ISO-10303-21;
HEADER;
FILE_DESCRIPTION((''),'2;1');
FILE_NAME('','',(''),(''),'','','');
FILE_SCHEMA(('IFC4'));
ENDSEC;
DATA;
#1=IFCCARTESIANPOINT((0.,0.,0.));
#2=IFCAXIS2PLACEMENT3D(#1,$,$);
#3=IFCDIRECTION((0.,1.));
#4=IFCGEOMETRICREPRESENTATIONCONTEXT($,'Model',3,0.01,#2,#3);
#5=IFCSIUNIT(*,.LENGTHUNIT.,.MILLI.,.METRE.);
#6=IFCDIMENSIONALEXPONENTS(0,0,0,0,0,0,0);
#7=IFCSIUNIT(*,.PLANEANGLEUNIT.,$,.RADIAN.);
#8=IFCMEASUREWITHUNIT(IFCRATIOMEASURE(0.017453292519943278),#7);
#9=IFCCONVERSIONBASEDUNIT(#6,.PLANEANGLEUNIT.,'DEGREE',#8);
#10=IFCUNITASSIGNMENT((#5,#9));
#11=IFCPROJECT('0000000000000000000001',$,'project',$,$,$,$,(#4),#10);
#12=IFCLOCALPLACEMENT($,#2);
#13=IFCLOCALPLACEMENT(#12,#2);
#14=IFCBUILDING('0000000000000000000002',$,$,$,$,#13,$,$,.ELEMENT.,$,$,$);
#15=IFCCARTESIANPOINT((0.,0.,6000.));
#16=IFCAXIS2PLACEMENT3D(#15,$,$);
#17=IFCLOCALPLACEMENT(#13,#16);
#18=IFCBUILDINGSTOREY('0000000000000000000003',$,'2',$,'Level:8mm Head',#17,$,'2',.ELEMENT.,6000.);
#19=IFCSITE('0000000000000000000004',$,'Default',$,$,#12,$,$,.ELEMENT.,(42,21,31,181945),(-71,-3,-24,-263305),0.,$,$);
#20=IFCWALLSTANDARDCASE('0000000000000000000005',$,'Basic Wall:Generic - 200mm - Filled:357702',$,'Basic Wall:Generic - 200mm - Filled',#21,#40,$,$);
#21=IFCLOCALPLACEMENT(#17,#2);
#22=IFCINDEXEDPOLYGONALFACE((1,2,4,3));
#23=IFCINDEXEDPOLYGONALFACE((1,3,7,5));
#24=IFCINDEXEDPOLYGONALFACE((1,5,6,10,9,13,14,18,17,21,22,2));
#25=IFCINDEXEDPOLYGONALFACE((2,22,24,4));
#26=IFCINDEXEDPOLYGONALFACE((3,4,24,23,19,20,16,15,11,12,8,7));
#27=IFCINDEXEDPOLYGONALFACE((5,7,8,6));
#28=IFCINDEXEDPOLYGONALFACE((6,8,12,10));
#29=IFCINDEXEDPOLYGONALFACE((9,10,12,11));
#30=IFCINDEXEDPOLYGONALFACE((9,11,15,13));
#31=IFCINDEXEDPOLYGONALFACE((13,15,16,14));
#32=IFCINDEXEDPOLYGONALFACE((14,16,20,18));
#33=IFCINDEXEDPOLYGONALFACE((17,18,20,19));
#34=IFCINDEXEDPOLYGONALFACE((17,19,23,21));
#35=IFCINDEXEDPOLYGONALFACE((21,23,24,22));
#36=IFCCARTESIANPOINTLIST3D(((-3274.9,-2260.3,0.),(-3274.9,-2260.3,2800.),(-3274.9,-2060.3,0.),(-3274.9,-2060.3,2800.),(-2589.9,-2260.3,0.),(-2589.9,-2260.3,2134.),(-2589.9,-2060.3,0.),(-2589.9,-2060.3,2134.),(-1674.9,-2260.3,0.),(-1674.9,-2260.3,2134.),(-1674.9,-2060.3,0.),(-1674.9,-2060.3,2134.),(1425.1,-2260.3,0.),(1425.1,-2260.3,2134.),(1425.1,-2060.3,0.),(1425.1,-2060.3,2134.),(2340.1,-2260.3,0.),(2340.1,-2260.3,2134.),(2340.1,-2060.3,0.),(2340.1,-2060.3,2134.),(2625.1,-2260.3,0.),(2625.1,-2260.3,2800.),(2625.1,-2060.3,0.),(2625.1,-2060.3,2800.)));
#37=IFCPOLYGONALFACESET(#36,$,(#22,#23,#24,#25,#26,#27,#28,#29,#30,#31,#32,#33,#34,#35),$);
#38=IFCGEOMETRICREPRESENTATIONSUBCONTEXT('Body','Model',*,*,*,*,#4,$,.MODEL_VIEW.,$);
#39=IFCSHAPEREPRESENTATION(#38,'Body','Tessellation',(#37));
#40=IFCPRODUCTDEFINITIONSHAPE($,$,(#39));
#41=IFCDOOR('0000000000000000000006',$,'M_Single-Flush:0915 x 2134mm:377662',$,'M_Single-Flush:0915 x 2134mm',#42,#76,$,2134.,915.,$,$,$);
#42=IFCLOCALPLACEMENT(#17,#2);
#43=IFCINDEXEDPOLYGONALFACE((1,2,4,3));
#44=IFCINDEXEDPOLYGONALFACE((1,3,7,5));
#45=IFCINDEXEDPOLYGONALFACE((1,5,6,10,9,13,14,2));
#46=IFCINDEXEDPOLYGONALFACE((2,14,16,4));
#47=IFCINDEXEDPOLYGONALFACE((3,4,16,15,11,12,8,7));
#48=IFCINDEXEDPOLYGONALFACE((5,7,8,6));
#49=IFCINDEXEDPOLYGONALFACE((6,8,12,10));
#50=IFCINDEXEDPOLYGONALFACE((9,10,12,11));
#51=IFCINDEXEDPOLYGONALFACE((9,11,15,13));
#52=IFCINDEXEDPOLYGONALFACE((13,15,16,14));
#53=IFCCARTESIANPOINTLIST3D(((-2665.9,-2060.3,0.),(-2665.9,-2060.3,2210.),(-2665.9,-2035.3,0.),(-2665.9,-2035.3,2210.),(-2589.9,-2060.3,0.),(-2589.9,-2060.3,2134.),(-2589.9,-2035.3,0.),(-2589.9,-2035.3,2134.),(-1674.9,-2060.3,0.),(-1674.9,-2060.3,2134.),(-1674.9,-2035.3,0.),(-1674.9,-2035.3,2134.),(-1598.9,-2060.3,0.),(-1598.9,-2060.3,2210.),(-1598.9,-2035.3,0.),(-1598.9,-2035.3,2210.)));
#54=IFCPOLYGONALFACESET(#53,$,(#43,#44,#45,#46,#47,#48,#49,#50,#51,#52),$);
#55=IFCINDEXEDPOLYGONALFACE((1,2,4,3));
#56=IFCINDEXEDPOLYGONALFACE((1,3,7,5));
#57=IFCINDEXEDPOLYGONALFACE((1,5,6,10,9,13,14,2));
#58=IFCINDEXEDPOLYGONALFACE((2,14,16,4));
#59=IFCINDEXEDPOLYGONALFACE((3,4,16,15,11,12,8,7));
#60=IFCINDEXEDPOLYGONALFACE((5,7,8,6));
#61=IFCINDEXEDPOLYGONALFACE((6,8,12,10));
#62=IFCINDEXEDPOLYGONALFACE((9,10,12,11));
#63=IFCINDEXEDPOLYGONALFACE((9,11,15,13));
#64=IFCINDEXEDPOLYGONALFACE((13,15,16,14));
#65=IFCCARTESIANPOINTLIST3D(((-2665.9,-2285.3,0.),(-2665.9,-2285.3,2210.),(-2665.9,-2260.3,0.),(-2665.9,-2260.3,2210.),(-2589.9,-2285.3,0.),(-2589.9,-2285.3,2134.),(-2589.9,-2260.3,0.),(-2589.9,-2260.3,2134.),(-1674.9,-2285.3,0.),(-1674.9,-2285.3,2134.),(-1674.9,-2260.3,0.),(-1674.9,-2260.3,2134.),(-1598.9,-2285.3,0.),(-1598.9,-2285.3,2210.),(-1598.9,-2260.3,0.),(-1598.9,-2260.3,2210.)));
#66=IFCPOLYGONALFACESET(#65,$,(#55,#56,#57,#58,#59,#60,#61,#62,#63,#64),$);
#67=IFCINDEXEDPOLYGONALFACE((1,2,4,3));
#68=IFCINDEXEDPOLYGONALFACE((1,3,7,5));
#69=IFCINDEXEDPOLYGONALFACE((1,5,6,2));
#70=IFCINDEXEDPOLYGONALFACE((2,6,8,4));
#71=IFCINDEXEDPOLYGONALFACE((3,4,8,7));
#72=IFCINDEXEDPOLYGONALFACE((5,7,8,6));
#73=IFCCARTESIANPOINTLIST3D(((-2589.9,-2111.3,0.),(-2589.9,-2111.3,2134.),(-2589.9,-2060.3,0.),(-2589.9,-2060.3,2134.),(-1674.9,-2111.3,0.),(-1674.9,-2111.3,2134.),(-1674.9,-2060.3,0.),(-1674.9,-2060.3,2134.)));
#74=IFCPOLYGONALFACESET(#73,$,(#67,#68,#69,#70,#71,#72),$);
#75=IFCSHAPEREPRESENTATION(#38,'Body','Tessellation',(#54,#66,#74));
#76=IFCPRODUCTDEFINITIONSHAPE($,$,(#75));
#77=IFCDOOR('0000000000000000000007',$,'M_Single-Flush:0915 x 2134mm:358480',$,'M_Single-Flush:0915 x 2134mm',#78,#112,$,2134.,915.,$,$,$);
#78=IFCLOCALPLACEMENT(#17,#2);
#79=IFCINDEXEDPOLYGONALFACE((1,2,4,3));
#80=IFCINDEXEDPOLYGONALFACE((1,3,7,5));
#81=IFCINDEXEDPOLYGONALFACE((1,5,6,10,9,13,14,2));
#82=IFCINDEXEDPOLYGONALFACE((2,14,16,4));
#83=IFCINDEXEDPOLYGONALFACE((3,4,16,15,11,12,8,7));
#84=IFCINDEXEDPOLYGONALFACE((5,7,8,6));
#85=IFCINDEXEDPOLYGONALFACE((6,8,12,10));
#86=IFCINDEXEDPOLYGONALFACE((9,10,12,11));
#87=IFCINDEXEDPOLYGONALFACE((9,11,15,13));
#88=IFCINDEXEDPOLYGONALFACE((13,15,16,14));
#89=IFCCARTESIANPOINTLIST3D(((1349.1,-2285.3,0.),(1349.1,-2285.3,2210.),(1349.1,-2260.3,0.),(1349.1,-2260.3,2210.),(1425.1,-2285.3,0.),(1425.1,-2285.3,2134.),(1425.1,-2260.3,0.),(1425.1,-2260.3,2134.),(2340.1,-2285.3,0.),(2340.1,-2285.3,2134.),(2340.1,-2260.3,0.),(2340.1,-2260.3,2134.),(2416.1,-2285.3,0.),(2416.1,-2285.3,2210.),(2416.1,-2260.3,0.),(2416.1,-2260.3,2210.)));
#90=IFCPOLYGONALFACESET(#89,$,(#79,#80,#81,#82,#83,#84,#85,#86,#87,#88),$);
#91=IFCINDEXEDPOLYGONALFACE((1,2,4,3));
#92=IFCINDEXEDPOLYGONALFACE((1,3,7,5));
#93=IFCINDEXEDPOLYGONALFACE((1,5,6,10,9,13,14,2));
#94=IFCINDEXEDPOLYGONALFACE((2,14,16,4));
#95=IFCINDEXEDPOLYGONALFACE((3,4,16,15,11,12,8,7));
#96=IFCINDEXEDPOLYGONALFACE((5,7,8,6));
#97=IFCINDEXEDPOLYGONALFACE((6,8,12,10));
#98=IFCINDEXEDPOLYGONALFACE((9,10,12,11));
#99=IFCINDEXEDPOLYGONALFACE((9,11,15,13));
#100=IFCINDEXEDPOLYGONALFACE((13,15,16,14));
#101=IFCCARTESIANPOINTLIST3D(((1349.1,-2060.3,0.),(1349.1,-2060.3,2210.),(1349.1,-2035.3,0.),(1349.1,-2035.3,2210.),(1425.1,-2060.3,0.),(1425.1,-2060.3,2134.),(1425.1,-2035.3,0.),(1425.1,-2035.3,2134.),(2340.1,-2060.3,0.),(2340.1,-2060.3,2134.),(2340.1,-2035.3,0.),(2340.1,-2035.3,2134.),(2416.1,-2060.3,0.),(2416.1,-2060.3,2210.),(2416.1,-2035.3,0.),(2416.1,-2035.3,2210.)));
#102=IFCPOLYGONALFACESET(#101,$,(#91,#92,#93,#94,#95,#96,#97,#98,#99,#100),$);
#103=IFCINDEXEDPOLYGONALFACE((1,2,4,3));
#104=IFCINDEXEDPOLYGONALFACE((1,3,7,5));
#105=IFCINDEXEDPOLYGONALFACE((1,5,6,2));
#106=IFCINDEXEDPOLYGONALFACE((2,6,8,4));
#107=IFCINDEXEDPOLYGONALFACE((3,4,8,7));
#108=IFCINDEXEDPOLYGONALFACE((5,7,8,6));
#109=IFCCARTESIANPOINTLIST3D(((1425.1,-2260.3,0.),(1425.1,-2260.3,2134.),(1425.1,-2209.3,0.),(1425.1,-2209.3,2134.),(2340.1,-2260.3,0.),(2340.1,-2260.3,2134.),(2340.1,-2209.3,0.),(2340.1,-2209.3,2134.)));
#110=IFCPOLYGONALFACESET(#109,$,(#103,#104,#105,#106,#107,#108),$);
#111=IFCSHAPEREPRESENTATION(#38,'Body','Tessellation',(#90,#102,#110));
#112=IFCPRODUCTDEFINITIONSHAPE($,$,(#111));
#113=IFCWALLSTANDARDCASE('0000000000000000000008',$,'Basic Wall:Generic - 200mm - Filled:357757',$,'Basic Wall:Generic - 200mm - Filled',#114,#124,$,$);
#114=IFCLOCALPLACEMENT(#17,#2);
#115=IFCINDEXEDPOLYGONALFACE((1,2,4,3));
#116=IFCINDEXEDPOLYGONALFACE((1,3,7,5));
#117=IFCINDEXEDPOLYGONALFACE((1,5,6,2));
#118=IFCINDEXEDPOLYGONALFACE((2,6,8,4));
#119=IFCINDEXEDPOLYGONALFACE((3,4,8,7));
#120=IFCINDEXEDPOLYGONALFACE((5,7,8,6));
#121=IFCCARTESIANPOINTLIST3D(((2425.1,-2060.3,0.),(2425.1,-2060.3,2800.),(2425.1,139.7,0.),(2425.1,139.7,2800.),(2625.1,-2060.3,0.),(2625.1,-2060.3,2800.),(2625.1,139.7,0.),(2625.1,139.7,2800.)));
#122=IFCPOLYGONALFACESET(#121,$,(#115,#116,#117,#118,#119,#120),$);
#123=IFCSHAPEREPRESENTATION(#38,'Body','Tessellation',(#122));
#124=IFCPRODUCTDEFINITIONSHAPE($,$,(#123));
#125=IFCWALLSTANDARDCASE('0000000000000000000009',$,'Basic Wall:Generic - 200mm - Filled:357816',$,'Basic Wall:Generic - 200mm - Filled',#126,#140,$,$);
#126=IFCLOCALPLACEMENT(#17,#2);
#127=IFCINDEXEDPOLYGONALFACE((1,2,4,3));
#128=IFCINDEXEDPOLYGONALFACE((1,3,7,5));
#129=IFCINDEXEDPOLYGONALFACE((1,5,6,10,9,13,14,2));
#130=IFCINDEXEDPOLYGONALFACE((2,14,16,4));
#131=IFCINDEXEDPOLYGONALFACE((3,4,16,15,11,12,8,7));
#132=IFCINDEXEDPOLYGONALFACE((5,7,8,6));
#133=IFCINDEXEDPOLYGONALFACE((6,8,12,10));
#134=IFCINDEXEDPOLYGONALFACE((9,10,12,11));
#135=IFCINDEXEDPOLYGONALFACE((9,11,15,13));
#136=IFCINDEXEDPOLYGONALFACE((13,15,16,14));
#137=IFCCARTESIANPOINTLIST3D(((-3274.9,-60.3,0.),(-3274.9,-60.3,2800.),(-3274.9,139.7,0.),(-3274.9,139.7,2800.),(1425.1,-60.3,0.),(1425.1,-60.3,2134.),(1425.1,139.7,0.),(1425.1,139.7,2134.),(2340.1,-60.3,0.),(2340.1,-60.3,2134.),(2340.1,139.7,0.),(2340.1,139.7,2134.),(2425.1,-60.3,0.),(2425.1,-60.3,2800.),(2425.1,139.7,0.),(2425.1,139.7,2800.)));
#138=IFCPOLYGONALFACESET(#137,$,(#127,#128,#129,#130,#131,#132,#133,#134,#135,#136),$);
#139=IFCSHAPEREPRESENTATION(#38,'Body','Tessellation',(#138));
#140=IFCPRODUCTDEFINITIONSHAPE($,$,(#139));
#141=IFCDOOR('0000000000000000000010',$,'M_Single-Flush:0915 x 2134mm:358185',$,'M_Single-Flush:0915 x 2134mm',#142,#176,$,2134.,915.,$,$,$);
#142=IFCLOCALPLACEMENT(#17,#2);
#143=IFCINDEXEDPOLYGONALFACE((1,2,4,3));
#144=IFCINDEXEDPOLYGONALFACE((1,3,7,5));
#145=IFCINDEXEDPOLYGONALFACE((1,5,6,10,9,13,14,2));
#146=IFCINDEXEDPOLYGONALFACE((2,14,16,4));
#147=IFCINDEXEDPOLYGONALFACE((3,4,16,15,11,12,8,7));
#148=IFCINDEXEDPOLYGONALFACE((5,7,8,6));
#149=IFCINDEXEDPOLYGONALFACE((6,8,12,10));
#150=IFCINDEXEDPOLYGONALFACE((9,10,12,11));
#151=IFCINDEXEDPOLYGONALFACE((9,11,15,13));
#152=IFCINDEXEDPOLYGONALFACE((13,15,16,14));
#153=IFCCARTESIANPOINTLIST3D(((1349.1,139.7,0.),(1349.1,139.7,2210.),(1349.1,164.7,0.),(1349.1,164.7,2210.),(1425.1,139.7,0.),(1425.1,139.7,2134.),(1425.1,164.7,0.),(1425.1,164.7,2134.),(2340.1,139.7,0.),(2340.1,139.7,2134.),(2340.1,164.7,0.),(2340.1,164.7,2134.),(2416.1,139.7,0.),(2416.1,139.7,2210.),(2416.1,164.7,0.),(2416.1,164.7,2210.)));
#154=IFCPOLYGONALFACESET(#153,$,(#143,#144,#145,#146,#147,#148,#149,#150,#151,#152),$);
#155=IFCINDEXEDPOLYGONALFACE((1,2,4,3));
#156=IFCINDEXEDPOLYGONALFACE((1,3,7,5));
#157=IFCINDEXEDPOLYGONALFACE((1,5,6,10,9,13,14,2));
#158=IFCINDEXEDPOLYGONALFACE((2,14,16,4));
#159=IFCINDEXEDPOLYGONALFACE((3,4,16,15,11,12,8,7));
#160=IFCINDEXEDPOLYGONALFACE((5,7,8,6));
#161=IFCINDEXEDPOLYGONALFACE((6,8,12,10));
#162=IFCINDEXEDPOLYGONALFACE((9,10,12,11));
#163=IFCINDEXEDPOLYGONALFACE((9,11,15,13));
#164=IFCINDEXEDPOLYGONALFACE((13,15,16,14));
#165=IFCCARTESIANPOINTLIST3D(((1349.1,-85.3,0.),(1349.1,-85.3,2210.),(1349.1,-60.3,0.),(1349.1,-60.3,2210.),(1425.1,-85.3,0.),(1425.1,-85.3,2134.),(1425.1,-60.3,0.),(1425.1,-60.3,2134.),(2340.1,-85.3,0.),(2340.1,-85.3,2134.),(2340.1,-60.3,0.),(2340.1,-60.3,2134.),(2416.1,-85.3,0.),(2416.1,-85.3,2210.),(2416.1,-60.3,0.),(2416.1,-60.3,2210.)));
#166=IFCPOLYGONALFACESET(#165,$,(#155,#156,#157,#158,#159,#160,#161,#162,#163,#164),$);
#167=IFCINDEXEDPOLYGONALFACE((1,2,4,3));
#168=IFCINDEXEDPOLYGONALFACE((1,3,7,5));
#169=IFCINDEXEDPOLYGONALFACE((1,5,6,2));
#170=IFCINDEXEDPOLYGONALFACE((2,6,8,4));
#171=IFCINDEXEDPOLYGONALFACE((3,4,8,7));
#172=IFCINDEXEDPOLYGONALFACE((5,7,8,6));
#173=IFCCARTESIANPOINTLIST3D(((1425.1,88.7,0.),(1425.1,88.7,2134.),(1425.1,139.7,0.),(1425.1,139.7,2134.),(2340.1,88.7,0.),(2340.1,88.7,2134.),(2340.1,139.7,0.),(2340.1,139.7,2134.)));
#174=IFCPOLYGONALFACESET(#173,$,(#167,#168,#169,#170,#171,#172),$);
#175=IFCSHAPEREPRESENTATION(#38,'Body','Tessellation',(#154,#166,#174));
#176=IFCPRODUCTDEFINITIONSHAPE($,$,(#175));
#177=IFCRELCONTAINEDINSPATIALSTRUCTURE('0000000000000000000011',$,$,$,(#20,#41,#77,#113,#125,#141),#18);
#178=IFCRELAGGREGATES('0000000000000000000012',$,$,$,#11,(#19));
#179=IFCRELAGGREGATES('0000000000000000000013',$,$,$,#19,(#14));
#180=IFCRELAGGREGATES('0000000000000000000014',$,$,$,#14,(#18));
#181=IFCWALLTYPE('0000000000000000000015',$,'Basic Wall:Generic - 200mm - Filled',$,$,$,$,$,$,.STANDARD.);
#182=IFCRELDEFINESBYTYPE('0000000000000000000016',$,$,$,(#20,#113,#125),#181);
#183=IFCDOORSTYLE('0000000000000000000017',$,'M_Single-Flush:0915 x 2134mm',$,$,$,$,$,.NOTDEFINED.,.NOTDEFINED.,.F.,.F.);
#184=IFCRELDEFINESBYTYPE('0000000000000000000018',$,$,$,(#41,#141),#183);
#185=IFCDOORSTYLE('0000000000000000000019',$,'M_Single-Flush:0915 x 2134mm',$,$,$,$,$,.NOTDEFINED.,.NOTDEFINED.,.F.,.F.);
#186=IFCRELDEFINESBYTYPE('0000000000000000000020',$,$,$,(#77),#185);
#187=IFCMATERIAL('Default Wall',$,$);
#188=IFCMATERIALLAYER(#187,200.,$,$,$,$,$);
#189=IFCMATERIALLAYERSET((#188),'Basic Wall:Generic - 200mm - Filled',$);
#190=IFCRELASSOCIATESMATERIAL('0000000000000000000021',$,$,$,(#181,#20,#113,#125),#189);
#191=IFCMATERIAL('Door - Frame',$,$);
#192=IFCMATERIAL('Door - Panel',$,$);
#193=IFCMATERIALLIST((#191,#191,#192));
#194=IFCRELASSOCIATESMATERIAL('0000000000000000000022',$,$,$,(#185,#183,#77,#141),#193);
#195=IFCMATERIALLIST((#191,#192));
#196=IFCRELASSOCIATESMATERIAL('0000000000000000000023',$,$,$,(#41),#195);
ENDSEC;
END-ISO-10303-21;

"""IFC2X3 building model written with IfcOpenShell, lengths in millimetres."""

from ifc_helpers import new_model, entity, si_unit, converted_unit, direction, frame, frame_2d, origin, place, context, subcontext, project, spatial, polyline, rectangle, outline, extrude, source, transform, mapped, material, material_list, layer, layer_set, layer_usage, type_object, type_shapes, element, fill, save


model = new_model("IFC2X3")

# Units and contexts
model_context = context("Model", 3, precision=0.01, world=origin(), true_north=direction((0.0, 1.0)))
body_context = subcontext(model_context, "Body", "Model", "MODEL_VIEW")
ifc_project = project(units=[si_unit("LENGTHUNIT", "METRE", prefix="MILLI"), converted_unit("PLANEANGLEUNIT", "DEGREE", entity("IfcRatioMeasure", 0.017453292519943278), si_unit("PLANEANGLEUNIT", "RADIAN"), dimensions=[0, 0, 0, 0, 0, 0, 0])], contexts=[model_context])

# Site, building, storey
site_placement = place(None, origin())
site = spatial("IfcSite", under=ifc_project, at=site_placement, Name="Default", CompositionType="ELEMENT", RefLatitude=(42, 21, 31, 181945), RefLongitude=(-71, -3, -24, -263305), RefElevation=0.0)
building_placement = place(site_placement, origin())
building = spatial("IfcBuilding", under=site, at=building_placement, CompositionType="ELEMENT")
storey_placement = place(building_placement, frame((0.0, 0.0, 6000.0)))
storey = spatial("IfcBuildingStorey", under=building, at=storey_placement, Name="2", ObjectType="Level:8mm Head", LongName="2", CompositionType="ELEMENT", Elevation=6000.0)

# Shared definitions
ifc_material_1 = material(Name="Default Wall")
ifc_layer_1 = layer(ifc_material_1, 200.0)
ifc_layer_set_1 = layer_set([ifc_layer_1], Name="Basic Wall:Generic - 200mm - Filled")
ifc_layer_usage_1 = layer_usage(ifc_layer_set_1, "AXIS2", "NEGATIVE", 100.0)
wall_type_1 = type_object("IfcWallType", Name="Basic Wall:Generic - 200mm - Filled", PredefinedType="STANDARD", material=ifc_layer_set_1)
ifc_material_2 = material(Name="Door - Frame")
ifc_material_3 = material(Name="Door - Panel")
ifc_material_list_1 = material_list([ifc_material_2, ifc_material_3])
ifc_material_list_2 = material_list([ifc_material_2, ifc_material_2, ifc_material_3])
door_style_1 = type_object("IfcDoorStyle", Name="M_Single-Flush:0915 x 2134mm", ConstructionType="NOTDEFINED", OperationType="NOTDEFINED", ParameterTakesPrecedence=False, Sizeable=False, material=ifc_material_list_2)
shared_shape_1 = source(origin(), body_context, "Body", "SweptSolid", [
    extrude(outline(polyline([(-533.5, -1124.0), (533.5, -1124.0), (533.5, 1086.0), (457.5, 1086.0), (457.5, -1048.0), (-457.5, -1048.0), (-457.5, 1086.0), (-533.5, 1086.0), (-533.5, -1124.0)])), frame((457.5, 200.0, 1086.0), z_axis=(0.0, 1.0, 0.0), x_axis=(1.0, 0.0, 0.0)), (0.0, 0.0, 1.0), 25.0),
    extrude(outline(polyline([(-1124.0, -533.5), (1086.0, -533.5), (1086.0, -457.5), (-1048.0, -457.5), (-1048.0, 457.5), (1086.0, 457.5), (1086.0, 533.5), (-1124.0, 533.5), (-1124.0, -533.5)])), frame((457.5, -25.0, 1086.0), z_axis=(0.0, 1.0, 0.0), x_axis=(0.0, 0.0, -1.0)), (0.0, 0.0, 1.0), 25.0),
    extrude(rectangle(XDim=51.0, YDim=915.0, at=frame_2d((0.0, 0.0), x_axis=(1.0, 0.0))), frame((457.5, 174.5, 0.0), z_axis=(0.0, 0.0, 1.0), x_axis=(0.0, 1.0, 0.0)), (0.0, 0.0, 1.0), 2134.0),
])
type_shapes(door_style_1, [shared_shape_1])

# Wall, openings, doors
wall_1_placement = place(storey_placement, frame((-3274.9, -2160.3, 0.0)))
wall_1 = element("IfcWallStandardCase", 1, at=wall_1_placement, inside=storey, type_object=wall_type_1, material=ifc_layer_usage_1, Name="Basic Wall:Generic - 200mm - Filled:357702", ObjectType="Basic Wall:Generic - 200mm - Filled", context=body_context, shape_type="SweptSolid", body=[
    extrude(rectangle(XDim=5900.0, YDim=200.0, at=frame_2d((2950.0, 0.0), x_axis=(1.0, 0.0))), origin(), (0.0, 0.0, 1.0), 2800.0),
])
opening_1_placement = place(wall_1_placement, frame((5615.0, 100.0, 0.0)))
opening_1 = element("IfcOpeningElement", 2, at=opening_1_placement, cuts=wall_1, ObjectType="Opening", context=body_context, shape_type="SweptSolid", body=[
    extrude(rectangle(XDim=915.0, YDim=2134.0, at=frame_2d((1067.0, 457.5), x_axis=(0.0, 1.0))), frame((0.0, 0.0, 0.0), z_axis=(0.0, -1.0, 0.0), x_axis=(0.0, 0.0, 1.0)), (0.0, 0.0, 1.0), 200.0),
])
opening_2_placement = place(wall_1_placement, frame((685.0, -100.0, 0.0)))
opening_2 = element("IfcOpeningElement", 3, at=opening_2_placement, cuts=wall_1, ObjectType="Opening", context=body_context, shape_type="SweptSolid", body=[
    extrude(rectangle(XDim=915.0, YDim=2134.0, at=frame_2d((1067.0, 457.5), x_axis=(0.0, -1.0))), frame((0.0, 0.0, 0.0), z_axis=(0.0, 1.0, 0.0), x_axis=(0.0, 0.0, 1.0)), (0.0, 0.0, 1.0), 200.0),
])
door_style_2 = type_object("IfcDoorStyle", Name="M_Single-Flush:0915 x 2134mm", ConstructionType="NOTDEFINED", OperationType="NOTDEFINED", ParameterTakesPrecedence=False, Sizeable=False, material=ifc_material_list_2)
shared_shape_2 = source(origin(), body_context, "Body", "SweptSolid", [
    extrude(outline(polyline([(-533.5, -1124.0), (533.5, -1124.0), (533.5, 1086.0), (457.5, 1086.0), (457.5, -1048.0), (-457.5, -1048.0), (-457.5, 1086.0), (-533.5, 1086.0), (-533.5, -1124.0)])), frame((457.5, 225.0, 1086.0), z_axis=(0.0, -1.0, 0.0), x_axis=(-1.0, 0.0, 0.0)), (0.0, 0.0, 1.0), 25.0),
    extrude(outline(polyline([(-1124.0, -533.5), (1086.0, -533.5), (1086.0, -457.5), (-1048.0, -457.5), (-1048.0, 457.5), (1086.0, 457.5), (1086.0, 533.5), (-1124.0, 533.5), (-1124.0, -533.5)])), frame((457.5, 0.0, 1086.0), z_axis=(0.0, -1.0, 0.0), x_axis=(0.0, 0.0, -1.0)), (0.0, 0.0, 1.0), 25.0),
    extrude(rectangle(XDim=915.0, YDim=51.0, at=frame_2d((0.0, 0.0), x_axis=(1.0, 0.0))), frame((457.5, 174.5, 0.0)), (0.0, 0.0, 1.0), 2134.0),
])
type_shapes(door_style_2, [shared_shape_2])
door_1_placement = place(opening_2_placement, origin())
door_1 = element("IfcDoor", 4, at=door_1_placement, inside=storey, type_object=door_style_2, material=ifc_material_list_1, Name="M_Single-Flush:0915 x 2134mm:377662", ObjectType="M_Single-Flush:0915 x 2134mm", OverallHeight=2134.0, OverallWidth=915.0, context=body_context, shape_type="MappedRepresentation", body=[
    mapped(shared_shape_2, transform((0.0, 0.0, 0.0), scale=1.0)),
])
fill(opening_2, door_1)
door_2_placement = place(opening_1_placement, frame((0.0, 0.0, 0.0), z_axis=(0.0, 0.0, 1.0), x_axis=(-1.0, 0.0, 0.0)))
door_2 = element("IfcDoor", 5, at=door_2_placement, inside=storey, type_object=door_style_1, material=ifc_material_list_2, Name="M_Single-Flush:0915 x 2134mm:358480", ObjectType="M_Single-Flush:0915 x 2134mm", OverallHeight=2134.0, OverallWidth=915.0, context=body_context, shape_type="MappedRepresentation", body=[
    mapped(shared_shape_1, transform((0.0, 0.0, 0.0), scale=1.0)),
])
fill(opening_1, door_2)

# Wall
wall_2_placement = place(storey_placement, frame((2525.1, -2060.3, 0.0), z_axis=(0.0, 0.0, 1.0), x_axis=(0.0, 1.0, 0.0)))
element("IfcWallStandardCase", 6, at=wall_2_placement, inside=storey, type_object=wall_type_1, material=ifc_layer_usage_1, Name="Basic Wall:Generic - 200mm - Filled:357757", ObjectType="Basic Wall:Generic - 200mm - Filled", context=body_context, shape_type="SweptSolid", body=[
    extrude(rectangle(XDim=2200.0, YDim=200.0, at=frame_2d((1100.0, 0.0), x_axis=(-1.0, 0.0))), origin(), (0.0, 0.0, 1.0), 2800.0),
])

# Wall, opening, door
wall_3_placement = place(storey_placement, frame((2425.1, 39.7, 0.0), z_axis=(0.0, 0.0, 1.0), x_axis=(-1.0, 0.0, 0.0)))
wall_3 = element("IfcWallStandardCase", 7, at=wall_3_placement, inside=storey, type_object=wall_type_1, material=ifc_layer_usage_1, Name="Basic Wall:Generic - 200mm - Filled:357816", ObjectType="Basic Wall:Generic - 200mm - Filled", context=body_context, shape_type="SweptSolid", body=[
    extrude(rectangle(XDim=5700.0, YDim=200.0, at=frame_2d((2850.0, 0.0), x_axis=(1.0, 0.0))), origin(), (0.0, 0.0, 1.0), 2800.0),
])
opening_3_placement = place(wall_3_placement, frame((1000.0, 100.0, 0.0)))
opening_3 = element("IfcOpeningElement", 8, at=opening_3_placement, cuts=wall_3, ObjectType="Opening", context=body_context, shape_type="SweptSolid", body=[
    extrude(rectangle(XDim=915.0, YDim=2134.0, at=frame_2d((1067.0, 457.5), x_axis=(0.0, -1.0))), frame((0.0, 0.0, 0.0), z_axis=(0.0, -1.0, 0.0), x_axis=(0.0, 0.0, 1.0)), (0.0, 0.0, 1.0), 200.0),
])
door_3_placement = place(opening_3_placement, frame((0.0, 0.0, 0.0), z_axis=(0.0, 0.0, 1.0), x_axis=(-1.0, 0.0, 0.0)))
door_3 = element("IfcDoor", 9, at=door_3_placement, inside=storey, type_object=door_style_2, material=ifc_material_list_2, Name="M_Single-Flush:0915 x 2134mm:358185", ObjectType="M_Single-Flush:0915 x 2134mm", OverallHeight=2134.0, OverallWidth=915.0, context=body_context, shape_type="MappedRepresentation", body=[
    mapped(shared_shape_2, transform((0.0, 0.0, 0.0), scale=1.0)),
])
fill(opening_3, door_3)

save(model, "model.ifc")
